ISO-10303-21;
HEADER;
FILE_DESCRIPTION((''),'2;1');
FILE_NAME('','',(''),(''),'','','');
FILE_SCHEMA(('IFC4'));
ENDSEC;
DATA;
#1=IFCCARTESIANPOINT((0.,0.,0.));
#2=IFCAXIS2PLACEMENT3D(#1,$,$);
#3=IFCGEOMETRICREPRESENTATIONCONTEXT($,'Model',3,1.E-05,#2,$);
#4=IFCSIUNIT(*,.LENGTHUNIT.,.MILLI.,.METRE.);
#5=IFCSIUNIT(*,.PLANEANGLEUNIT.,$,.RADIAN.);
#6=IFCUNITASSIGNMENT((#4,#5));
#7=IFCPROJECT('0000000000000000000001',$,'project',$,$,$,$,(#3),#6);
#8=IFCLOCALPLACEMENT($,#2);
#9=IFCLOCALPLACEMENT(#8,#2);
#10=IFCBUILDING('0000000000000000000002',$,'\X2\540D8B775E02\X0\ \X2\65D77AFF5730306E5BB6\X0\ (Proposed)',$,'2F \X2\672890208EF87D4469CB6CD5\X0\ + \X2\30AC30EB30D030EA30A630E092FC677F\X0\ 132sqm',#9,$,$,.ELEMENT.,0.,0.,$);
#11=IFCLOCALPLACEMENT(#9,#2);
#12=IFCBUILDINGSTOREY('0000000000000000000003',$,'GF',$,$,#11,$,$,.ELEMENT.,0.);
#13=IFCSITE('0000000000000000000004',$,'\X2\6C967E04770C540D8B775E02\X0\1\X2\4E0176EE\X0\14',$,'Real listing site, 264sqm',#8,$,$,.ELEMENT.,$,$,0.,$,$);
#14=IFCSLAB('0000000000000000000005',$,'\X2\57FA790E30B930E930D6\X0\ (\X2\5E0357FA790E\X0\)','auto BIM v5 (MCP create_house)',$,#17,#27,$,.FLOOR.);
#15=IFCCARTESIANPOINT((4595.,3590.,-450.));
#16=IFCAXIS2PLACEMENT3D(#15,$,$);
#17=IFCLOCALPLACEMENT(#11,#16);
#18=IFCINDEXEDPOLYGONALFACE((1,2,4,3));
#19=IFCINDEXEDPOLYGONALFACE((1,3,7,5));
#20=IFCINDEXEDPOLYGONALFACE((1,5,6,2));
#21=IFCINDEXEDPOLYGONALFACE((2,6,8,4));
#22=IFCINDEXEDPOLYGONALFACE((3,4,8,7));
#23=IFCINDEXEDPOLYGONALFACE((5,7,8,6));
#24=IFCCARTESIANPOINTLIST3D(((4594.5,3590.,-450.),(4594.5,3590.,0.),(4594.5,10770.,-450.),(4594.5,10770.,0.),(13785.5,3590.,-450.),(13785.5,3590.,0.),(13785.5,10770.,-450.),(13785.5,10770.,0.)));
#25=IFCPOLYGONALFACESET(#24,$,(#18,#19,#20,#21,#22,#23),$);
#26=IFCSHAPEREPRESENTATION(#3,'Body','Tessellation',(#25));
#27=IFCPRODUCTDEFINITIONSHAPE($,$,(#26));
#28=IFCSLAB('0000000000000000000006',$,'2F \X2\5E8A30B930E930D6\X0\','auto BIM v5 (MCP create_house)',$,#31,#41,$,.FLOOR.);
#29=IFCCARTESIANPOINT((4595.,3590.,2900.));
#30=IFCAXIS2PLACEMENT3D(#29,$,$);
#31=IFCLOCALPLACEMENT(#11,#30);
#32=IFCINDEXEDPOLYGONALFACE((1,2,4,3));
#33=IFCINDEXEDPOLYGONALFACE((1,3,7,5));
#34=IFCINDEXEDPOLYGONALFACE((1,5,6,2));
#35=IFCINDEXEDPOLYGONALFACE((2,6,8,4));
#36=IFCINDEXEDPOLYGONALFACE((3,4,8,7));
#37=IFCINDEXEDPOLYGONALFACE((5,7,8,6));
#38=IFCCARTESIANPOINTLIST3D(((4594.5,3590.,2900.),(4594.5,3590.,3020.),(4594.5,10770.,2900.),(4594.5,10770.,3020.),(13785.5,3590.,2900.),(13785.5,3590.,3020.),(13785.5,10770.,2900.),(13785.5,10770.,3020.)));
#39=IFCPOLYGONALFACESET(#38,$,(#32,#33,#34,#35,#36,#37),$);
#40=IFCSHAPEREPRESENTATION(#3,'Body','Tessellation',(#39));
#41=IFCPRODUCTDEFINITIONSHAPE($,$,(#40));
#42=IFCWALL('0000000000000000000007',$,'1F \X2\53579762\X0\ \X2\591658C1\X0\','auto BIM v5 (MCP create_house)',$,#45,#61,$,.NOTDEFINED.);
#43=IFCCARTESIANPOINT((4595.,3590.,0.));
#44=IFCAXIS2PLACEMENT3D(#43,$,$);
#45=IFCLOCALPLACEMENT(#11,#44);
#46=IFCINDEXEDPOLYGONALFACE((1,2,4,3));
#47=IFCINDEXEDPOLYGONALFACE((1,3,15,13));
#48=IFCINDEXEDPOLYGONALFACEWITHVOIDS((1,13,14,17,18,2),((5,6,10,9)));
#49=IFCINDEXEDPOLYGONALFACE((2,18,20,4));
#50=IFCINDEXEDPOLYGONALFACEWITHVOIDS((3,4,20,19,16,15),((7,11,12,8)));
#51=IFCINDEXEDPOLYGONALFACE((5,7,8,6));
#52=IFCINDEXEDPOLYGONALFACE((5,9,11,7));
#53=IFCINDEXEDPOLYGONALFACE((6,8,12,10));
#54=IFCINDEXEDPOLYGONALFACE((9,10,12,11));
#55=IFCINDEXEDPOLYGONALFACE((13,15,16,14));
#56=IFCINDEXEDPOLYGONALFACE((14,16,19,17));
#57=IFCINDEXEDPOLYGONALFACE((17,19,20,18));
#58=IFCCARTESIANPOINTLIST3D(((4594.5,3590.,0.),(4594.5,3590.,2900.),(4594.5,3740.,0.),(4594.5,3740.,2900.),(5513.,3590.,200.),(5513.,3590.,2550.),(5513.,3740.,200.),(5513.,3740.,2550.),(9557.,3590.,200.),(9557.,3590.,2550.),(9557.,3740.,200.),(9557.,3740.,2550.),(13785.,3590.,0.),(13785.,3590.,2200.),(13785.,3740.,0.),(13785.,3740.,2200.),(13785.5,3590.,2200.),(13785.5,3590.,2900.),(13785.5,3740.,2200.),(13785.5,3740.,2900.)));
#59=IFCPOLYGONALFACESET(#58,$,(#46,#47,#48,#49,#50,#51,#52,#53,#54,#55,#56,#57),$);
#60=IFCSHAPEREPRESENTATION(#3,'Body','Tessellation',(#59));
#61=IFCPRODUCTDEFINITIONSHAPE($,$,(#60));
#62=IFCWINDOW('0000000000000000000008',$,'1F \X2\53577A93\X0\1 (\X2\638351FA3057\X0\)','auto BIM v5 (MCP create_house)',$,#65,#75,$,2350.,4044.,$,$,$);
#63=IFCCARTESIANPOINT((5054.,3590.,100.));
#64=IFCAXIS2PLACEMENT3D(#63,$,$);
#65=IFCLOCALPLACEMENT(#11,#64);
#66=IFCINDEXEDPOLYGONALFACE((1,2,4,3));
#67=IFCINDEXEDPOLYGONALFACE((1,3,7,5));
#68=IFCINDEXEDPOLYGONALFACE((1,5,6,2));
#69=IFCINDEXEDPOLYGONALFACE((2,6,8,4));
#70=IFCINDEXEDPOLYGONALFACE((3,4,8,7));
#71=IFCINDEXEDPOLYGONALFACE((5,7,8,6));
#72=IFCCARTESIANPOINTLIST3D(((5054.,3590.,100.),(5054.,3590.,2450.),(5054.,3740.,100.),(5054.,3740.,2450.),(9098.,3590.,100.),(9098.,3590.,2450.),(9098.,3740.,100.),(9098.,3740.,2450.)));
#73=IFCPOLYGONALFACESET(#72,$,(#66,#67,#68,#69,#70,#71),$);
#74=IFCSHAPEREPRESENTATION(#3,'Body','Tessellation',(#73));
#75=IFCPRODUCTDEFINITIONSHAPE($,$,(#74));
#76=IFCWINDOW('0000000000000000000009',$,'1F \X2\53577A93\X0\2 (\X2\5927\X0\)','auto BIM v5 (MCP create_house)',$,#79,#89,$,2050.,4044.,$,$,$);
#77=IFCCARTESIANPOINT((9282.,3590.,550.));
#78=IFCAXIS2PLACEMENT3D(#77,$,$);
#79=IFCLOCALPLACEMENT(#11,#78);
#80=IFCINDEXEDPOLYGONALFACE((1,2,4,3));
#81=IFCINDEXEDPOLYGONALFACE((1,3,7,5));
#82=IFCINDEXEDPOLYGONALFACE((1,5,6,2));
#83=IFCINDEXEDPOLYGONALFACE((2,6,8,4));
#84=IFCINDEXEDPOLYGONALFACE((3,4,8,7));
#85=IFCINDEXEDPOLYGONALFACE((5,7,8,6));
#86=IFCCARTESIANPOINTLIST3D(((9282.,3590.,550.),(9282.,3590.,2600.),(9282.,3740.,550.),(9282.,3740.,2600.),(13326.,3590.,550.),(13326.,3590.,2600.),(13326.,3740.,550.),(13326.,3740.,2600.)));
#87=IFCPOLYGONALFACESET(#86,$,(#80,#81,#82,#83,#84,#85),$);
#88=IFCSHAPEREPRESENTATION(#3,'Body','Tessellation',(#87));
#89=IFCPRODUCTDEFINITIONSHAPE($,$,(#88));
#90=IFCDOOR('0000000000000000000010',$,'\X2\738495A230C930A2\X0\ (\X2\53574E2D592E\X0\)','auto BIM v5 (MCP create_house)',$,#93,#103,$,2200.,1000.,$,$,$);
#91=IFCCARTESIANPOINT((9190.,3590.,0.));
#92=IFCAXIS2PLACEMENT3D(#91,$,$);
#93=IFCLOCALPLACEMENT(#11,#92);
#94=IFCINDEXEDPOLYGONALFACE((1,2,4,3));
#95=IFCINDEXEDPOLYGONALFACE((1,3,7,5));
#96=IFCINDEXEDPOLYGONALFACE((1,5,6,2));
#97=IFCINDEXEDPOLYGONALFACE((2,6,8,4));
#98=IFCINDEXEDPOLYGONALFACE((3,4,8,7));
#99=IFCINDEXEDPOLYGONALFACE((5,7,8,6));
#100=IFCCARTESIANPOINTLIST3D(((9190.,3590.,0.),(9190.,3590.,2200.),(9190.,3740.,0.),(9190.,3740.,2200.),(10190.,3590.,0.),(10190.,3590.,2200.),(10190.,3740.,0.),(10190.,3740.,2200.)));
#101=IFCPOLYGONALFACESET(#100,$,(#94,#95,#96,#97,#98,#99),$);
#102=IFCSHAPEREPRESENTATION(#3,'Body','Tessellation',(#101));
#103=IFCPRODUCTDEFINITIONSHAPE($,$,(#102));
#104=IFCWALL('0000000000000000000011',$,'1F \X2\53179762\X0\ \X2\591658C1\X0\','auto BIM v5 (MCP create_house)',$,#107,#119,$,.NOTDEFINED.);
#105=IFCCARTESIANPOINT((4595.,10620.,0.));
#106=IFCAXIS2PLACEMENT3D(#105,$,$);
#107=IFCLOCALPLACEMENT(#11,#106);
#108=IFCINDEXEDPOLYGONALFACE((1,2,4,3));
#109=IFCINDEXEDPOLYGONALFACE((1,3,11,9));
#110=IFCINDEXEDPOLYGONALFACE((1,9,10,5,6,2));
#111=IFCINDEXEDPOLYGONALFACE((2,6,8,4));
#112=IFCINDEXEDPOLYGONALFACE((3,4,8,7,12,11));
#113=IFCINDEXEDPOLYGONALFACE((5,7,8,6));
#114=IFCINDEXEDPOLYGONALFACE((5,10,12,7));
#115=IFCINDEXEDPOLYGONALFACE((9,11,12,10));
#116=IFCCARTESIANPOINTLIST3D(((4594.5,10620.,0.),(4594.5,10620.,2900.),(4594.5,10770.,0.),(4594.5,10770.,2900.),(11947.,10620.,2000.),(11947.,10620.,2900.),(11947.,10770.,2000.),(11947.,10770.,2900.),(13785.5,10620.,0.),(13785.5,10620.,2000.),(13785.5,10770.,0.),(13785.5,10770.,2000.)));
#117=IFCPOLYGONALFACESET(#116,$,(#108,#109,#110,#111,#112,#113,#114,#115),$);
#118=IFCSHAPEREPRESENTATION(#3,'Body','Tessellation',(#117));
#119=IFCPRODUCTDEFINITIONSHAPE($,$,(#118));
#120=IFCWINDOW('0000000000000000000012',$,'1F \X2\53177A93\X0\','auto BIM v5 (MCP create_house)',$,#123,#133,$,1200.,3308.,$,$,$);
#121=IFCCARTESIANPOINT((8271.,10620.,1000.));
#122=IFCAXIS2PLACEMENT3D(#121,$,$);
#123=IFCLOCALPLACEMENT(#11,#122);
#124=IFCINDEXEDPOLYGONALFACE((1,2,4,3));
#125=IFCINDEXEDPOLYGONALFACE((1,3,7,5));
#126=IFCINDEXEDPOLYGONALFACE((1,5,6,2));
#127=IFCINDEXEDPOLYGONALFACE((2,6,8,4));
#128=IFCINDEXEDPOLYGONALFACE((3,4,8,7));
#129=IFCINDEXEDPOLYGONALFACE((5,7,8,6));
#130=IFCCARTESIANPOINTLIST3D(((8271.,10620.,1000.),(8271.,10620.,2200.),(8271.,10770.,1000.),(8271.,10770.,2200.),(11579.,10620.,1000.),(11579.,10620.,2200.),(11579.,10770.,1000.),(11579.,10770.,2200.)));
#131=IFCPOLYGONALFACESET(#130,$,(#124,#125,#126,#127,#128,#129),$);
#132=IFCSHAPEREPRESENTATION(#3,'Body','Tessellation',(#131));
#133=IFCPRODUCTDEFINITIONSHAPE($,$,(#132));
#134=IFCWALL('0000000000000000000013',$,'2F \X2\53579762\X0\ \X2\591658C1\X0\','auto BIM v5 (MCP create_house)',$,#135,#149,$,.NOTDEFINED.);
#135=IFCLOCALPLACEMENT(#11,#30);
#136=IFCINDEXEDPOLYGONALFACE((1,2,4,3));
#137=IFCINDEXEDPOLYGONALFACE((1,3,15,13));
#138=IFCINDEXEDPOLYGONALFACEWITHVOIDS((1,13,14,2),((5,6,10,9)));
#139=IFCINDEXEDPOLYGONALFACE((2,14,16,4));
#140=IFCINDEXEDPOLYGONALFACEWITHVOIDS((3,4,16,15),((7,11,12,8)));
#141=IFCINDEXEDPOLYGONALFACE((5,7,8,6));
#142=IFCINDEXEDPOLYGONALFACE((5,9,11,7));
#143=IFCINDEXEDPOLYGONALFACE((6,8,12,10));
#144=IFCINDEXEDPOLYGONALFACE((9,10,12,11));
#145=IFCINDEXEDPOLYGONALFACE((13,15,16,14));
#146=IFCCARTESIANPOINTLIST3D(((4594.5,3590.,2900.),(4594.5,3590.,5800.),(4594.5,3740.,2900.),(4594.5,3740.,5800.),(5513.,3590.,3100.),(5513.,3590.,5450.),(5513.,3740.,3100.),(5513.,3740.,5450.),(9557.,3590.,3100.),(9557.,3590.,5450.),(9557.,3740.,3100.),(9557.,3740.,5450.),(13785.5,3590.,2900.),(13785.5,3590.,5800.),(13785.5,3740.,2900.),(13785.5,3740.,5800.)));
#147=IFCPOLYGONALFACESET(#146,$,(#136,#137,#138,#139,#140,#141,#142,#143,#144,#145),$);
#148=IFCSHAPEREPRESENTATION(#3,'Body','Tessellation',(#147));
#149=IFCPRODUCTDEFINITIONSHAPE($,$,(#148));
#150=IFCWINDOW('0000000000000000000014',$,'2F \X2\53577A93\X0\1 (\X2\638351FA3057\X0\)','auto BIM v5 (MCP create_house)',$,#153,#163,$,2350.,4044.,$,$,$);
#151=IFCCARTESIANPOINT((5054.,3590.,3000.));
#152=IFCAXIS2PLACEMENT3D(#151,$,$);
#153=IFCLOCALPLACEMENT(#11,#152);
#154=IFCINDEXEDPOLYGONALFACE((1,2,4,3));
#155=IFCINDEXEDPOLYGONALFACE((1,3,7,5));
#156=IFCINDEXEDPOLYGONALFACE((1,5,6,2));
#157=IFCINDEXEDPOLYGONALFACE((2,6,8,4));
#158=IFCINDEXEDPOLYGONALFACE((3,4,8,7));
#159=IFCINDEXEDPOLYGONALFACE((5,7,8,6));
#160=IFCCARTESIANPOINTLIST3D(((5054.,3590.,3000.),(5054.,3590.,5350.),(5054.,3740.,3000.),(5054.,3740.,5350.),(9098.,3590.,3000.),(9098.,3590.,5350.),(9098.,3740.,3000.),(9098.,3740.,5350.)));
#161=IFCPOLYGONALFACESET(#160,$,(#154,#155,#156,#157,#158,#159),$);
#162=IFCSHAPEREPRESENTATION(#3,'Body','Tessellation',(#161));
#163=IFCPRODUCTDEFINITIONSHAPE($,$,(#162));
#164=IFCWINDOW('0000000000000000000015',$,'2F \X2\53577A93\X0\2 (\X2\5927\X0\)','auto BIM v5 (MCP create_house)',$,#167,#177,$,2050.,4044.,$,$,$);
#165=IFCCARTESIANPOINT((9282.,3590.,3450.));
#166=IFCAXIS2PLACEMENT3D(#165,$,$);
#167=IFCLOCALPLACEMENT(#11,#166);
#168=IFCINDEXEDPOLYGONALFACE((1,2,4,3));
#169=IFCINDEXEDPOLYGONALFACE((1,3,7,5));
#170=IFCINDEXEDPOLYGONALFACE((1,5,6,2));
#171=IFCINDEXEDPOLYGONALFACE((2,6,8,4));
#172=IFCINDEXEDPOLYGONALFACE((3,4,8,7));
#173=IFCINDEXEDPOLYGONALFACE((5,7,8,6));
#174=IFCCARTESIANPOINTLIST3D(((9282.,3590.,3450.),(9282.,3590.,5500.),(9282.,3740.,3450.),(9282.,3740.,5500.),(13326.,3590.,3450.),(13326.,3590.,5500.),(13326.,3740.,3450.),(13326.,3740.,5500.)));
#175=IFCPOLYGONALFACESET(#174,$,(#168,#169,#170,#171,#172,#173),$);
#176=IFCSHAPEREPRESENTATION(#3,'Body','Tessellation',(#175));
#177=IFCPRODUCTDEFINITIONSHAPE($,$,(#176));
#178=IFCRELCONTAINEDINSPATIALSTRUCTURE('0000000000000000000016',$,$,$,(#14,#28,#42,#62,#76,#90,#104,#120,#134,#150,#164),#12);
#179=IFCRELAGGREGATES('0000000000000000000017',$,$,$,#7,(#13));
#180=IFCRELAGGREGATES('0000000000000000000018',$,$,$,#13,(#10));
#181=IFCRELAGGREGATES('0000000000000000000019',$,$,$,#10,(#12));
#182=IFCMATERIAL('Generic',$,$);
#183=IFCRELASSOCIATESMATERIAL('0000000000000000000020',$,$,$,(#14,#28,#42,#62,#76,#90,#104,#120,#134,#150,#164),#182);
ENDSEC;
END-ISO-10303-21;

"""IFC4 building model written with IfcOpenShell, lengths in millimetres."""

from ifc_helpers import new_model, si_unit, frame, frame_2d, origin, place, context, project, spatial, rectangle, extrude, material, element, fill, save


model = new_model("IFC4")

# Units and contexts
model_context = context("Model", 3, precision=1e-05, world=origin())
ifc_project = project(units=[si_unit("LENGTHUNIT", "METRE", prefix="MILLI"), si_unit("PLANEANGLEUNIT", "RADIAN")], contexts=[model_context])

# Site, building, storey
site_placement = place(None, origin())
site = spatial("IfcSite", under=ifc_project, at=site_placement, Name="沖縄県名護市1丁目14", ObjectType="Real listing site, 264sqm", CompositionType="ELEMENT", RefElevation=0.0)
building_placement = place(site_placement, origin())
building = spatial("IfcBuilding", under=site, at=building_placement, Name="名護市 旗竿地の家 (Proposed)", ObjectType="2F 木造軸組構法 + ガルバリウム鋼板 132sqm", CompositionType="ELEMENT", ElevationOfRefHeight=0.0, ElevationOfTerrain=0.0)
storey_placement = place(building_placement, origin())
storey = spatial("IfcBuildingStorey", under=building, at=storey_placement, Name="GF", CompositionType="ELEMENT", Elevation=0.0)

# Slabs
ifc_material = material(Name="Generic")
slab_1_placement = place(storey_placement, frame((4595.0, 3590.0, -450.0)))
element("IfcSlab", 1, at=slab_1_placement, inside=storey, material=ifc_material, Name="基礎スラブ (布基礎)", Description="auto BIM v5 (MCP create_house)", PredefinedType="FLOOR", context=model_context, shape_type="SweptSolid", body=[
    extrude(rectangle(XDim=9191.0, YDim=7180.0, at=frame_2d((4595.0, 3590.0))), frame((4595.0, 3590.0, -450.0)), (0.0, 0.0, 1.0), 450.0),
])
slab_2_placement = place(storey_placement, frame((4595.0, 3590.0, 2900.0)))
element("IfcSlab", 2, at=slab_2_placement, inside=storey, material=ifc_material, Name="2F 床スラブ", Description="auto BIM v5 (MCP create_house)", PredefinedType="FLOOR", context=model_context, shape_type="SweptSolid", body=[
    extrude(rectangle(XDim=9191.0, YDim=7180.0, at=frame_2d((4595.0, 3590.0))), frame((4595.0, 3590.0, 2900.0)), (0.0, 0.0, 1.0), 120.0),
])

# Wall, openings, windows, door
wall_1_placement = place(storey_placement, frame((4595.0, 3590.0, 0.0)))
wall_1 = element("IfcWall", 3, at=wall_1_placement, inside=storey, material=ifc_material, Name="1F 南面 外壁", Description="auto BIM v5 (MCP create_house)", PredefinedType="NOTDEFINED", context=model_context, shape_type="SweptSolid", body=[
    extrude(rectangle(XDim=9191.0, YDim=150.0, at=frame_2d((4595.0, 75.0))), frame((4595.0, 3590.0, 0.0)), (0.0, 0.0, 1.0), 2900.0),
])
opening_1_placement = place(storey_placement, frame((5054.0, 3590.0, 100.0)))
opening_1 = element("IfcOpeningElement", 4, at=opening_1_placement, cuts=wall_1, PredefinedType="NOTDEFINED", context=model_context, shape_type="SweptSolid", body=[
    extrude(rectangle(XDim=4044.0, YDim=150.0, at=frame_2d((2022.0, 75.0))), frame((5054.0, 3590.0, 100.0)), (0.0, 0.0, 1.0), 2350.0),
])
opening_2_placement = place(storey_placement, frame((9282.0, 3590.0, 550.0)))
opening_2 = element("IfcOpeningElement", 5, at=opening_2_placement, cuts=wall_1, PredefinedType="NOTDEFINED", context=model_context, shape_type="SweptSolid", body=[
    extrude(rectangle(XDim=4044.0, YDim=150.0, at=frame_2d((2022.0, 75.0))), frame((9282.0, 3590.0, 550.0)), (0.0, 0.0, 1.0), 2050.0),
])
opening_3_placement = place(storey_placement, frame((9190.0, 3590.0, 0.0)))
opening_3 = element("IfcOpeningElement", 6, at=opening_3_placement, cuts=wall_1, PredefinedType="NOTDEFINED", context=model_context, shape_type="SweptSolid", body=[
    extrude(rectangle(XDim=1000.0, YDim=150.0, at=frame_2d((500.0, 75.0))), frame((9190.0, 3590.0, 0.0)), (0.0, 0.0, 1.0), 2200.0),
])
window_1_placement = place(storey_placement, frame((5054.0, 3590.0, 100.0)))
window_1 = element("IfcWindow", 7, at=window_1_placement, inside=storey, material=ifc_material, Name="1F 南窓1 (掃出し)", Description="auto BIM v5 (MCP create_house)", OverallHeight=2350.0, OverallWidth=4044.0, context=model_context, shape_type="SweptSolid", body=[
    extrude(rectangle(XDim=4044.0, YDim=150.0, at=frame_2d((2022.0, 75.0))), frame((5054.0, 3590.0, 100.0)), (0.0, 0.0, 1.0), 2350.0),
])
fill(opening_1, window_1)
window_2_placement = place(storey_placement, frame((9282.0, 3590.0, 550.0)))
window_2 = element("IfcWindow", 8, at=window_2_placement, inside=storey, material=ifc_material, Name="1F 南窓2 (大)", Description="auto BIM v5 (MCP create_house)", OverallHeight=2050.0, OverallWidth=4044.0, context=model_context, shape_type="SweptSolid", body=[
    extrude(rectangle(XDim=4044.0, YDim=150.0, at=frame_2d((2022.0, 75.0))), frame((9282.0, 3590.0, 550.0)), (0.0, 0.0, 1.0), 2050.0),
])
fill(opening_2, window_2)
door_placement = place(storey_placement, frame((9190.0, 3590.0, 0.0)))
door = element("IfcDoor", 9, at=door_placement, inside=storey, material=ifc_material, Name="玄関ドア (南中央)", Description="auto BIM v5 (MCP create_house)", OverallHeight=2200.0, OverallWidth=1000.0, context=model_context, shape_type="SweptSolid", body=[
    extrude(rectangle(XDim=1000.0, YDim=150.0, at=frame_2d((500.0, 75.0))), frame((9190.0, 3590.0, 0.0)), (0.0, 0.0, 1.0), 2200.0),
])
fill(opening_3, door)

# Wall, opening, window
wall_2_placement = place(storey_placement, frame((4595.0, 10620.0, 0.0)))
wall_2 = element("IfcWall", 10, at=wall_2_placement, inside=storey, material=ifc_material, Name="1F 北面 外壁", Description="auto BIM v5 (MCP create_house)", PredefinedType="NOTDEFINED", context=model_context, shape_type="SweptSolid", body=[
    extrude(rectangle(XDim=9191.0, YDim=150.0, at=frame_2d((4595.0, 75.0))), frame((4595.0, 10620.0, 0.0)), (0.0, 0.0, 1.0), 2900.0),
])
opening_4_placement = place(storey_placement, frame((8271.0, 10620.0, 1000.0)))
opening_4 = element("IfcOpeningElement", 11, at=opening_4_placement, cuts=wall_2, PredefinedType="NOTDEFINED", context=model_context, shape_type="SweptSolid", body=[
    extrude(rectangle(XDim=3308.0, YDim=150.0, at=frame_2d((1654.0, 75.0))), frame((8271.0, 10620.0, 1000.0)), (0.0, 0.0, 1.0), 1200.0),
])
window_3_placement = place(storey_placement, frame((8271.0, 10620.0, 1000.0)))
window_3 = element("IfcWindow", 12, at=window_3_placement, inside=storey, material=ifc_material, Name="1F 北窓", Description="auto BIM v5 (MCP create_house)", OverallHeight=1200.0, OverallWidth=3308.0, context=model_context, shape_type="SweptSolid", body=[
    extrude(rectangle(XDim=3308.0, YDim=150.0, at=frame_2d((1654.0, 75.0))), frame((8271.0, 10620.0, 1000.0)), (0.0, 0.0, 1.0), 1200.0),
])
fill(opening_4, window_3)

# Wall, openings, windows
wall_3_placement = place(storey_placement, frame((4595.0, 3590.0, 2900.0)))
wall_3 = element("IfcWall", 13, at=wall_3_placement, inside=storey, material=ifc_material, Name="2F 南面 外壁", Description="auto BIM v5 (MCP create_house)", PredefinedType="NOTDEFINED", context=model_context, shape_type="SweptSolid", body=[
    extrude(rectangle(XDim=9191.0, YDim=150.0, at=frame_2d((4595.0, 75.0))), frame((4595.0, 3590.0, 2900.0)), (0.0, 0.0, 1.0), 2900.0),
])
opening_5_placement = place(storey_placement, frame((5054.0, 3590.0, 3000.0)))
opening_5 = element("IfcOpeningElement", 14, at=opening_5_placement, cuts=wall_3, PredefinedType="NOTDEFINED", context=model_context, shape_type="SweptSolid", body=[
    extrude(rectangle(XDim=4044.0, YDim=150.0, at=frame_2d((2022.0, 75.0))), frame((5054.0, 3590.0, 3000.0)), (0.0, 0.0, 1.0), 2350.0),
])
opening_6_placement = place(storey_placement, frame((9282.0, 3590.0, 3450.0)))
opening_6 = element("IfcOpeningElement", 15, at=opening_6_placement, cuts=wall_3, PredefinedType="NOTDEFINED", context=model_context, shape_type="SweptSolid", body=[
    extrude(rectangle(XDim=4044.0, YDim=150.0, at=frame_2d((2022.0, 75.0))), frame((9282.0, 3590.0, 3450.0)), (0.0, 0.0, 1.0), 2050.0),
])
window_4_placement = place(storey_placement, frame((5054.0, 3590.0, 3000.0)))
window_4 = element("IfcWindow", 16, at=window_4_placement, inside=storey, material=ifc_material, Name="2F 南窓1 (掃出し)", Description="auto BIM v5 (MCP create_house)", OverallHeight=2350.0, OverallWidth=4044.0, context=model_context, shape_type="SweptSolid", body=[
    extrude(rectangle(XDim=4044.0, YDim=150.0, at=frame_2d((2022.0, 75.0))), frame((5054.0, 3590.0, 3000.0)), (0.0, 0.0, 1.0), 2350.0),
])
fill(opening_5, window_4)
window_5_placement = place(storey_placement, frame((9282.0, 3590.0, 3450.0)))
window_5 = element("IfcWindow", 17, at=window_5_placement, inside=storey, material=ifc_material, Name="2F 南窓2 (大)", Description="auto BIM v5 (MCP create_house)", OverallHeight=2050.0, OverallWidth=4044.0, context=model_context, shape_type="SweptSolid", body=[
    extrude(rectangle(XDim=4044.0, YDim=150.0, at=frame_2d((2022.0, 75.0))), frame((9282.0, 3590.0, 3450.0)), (0.0, 0.0, 1.0), 2050.0),
])
fill(opening_6, window_5)

save(model, "model.ifc")
